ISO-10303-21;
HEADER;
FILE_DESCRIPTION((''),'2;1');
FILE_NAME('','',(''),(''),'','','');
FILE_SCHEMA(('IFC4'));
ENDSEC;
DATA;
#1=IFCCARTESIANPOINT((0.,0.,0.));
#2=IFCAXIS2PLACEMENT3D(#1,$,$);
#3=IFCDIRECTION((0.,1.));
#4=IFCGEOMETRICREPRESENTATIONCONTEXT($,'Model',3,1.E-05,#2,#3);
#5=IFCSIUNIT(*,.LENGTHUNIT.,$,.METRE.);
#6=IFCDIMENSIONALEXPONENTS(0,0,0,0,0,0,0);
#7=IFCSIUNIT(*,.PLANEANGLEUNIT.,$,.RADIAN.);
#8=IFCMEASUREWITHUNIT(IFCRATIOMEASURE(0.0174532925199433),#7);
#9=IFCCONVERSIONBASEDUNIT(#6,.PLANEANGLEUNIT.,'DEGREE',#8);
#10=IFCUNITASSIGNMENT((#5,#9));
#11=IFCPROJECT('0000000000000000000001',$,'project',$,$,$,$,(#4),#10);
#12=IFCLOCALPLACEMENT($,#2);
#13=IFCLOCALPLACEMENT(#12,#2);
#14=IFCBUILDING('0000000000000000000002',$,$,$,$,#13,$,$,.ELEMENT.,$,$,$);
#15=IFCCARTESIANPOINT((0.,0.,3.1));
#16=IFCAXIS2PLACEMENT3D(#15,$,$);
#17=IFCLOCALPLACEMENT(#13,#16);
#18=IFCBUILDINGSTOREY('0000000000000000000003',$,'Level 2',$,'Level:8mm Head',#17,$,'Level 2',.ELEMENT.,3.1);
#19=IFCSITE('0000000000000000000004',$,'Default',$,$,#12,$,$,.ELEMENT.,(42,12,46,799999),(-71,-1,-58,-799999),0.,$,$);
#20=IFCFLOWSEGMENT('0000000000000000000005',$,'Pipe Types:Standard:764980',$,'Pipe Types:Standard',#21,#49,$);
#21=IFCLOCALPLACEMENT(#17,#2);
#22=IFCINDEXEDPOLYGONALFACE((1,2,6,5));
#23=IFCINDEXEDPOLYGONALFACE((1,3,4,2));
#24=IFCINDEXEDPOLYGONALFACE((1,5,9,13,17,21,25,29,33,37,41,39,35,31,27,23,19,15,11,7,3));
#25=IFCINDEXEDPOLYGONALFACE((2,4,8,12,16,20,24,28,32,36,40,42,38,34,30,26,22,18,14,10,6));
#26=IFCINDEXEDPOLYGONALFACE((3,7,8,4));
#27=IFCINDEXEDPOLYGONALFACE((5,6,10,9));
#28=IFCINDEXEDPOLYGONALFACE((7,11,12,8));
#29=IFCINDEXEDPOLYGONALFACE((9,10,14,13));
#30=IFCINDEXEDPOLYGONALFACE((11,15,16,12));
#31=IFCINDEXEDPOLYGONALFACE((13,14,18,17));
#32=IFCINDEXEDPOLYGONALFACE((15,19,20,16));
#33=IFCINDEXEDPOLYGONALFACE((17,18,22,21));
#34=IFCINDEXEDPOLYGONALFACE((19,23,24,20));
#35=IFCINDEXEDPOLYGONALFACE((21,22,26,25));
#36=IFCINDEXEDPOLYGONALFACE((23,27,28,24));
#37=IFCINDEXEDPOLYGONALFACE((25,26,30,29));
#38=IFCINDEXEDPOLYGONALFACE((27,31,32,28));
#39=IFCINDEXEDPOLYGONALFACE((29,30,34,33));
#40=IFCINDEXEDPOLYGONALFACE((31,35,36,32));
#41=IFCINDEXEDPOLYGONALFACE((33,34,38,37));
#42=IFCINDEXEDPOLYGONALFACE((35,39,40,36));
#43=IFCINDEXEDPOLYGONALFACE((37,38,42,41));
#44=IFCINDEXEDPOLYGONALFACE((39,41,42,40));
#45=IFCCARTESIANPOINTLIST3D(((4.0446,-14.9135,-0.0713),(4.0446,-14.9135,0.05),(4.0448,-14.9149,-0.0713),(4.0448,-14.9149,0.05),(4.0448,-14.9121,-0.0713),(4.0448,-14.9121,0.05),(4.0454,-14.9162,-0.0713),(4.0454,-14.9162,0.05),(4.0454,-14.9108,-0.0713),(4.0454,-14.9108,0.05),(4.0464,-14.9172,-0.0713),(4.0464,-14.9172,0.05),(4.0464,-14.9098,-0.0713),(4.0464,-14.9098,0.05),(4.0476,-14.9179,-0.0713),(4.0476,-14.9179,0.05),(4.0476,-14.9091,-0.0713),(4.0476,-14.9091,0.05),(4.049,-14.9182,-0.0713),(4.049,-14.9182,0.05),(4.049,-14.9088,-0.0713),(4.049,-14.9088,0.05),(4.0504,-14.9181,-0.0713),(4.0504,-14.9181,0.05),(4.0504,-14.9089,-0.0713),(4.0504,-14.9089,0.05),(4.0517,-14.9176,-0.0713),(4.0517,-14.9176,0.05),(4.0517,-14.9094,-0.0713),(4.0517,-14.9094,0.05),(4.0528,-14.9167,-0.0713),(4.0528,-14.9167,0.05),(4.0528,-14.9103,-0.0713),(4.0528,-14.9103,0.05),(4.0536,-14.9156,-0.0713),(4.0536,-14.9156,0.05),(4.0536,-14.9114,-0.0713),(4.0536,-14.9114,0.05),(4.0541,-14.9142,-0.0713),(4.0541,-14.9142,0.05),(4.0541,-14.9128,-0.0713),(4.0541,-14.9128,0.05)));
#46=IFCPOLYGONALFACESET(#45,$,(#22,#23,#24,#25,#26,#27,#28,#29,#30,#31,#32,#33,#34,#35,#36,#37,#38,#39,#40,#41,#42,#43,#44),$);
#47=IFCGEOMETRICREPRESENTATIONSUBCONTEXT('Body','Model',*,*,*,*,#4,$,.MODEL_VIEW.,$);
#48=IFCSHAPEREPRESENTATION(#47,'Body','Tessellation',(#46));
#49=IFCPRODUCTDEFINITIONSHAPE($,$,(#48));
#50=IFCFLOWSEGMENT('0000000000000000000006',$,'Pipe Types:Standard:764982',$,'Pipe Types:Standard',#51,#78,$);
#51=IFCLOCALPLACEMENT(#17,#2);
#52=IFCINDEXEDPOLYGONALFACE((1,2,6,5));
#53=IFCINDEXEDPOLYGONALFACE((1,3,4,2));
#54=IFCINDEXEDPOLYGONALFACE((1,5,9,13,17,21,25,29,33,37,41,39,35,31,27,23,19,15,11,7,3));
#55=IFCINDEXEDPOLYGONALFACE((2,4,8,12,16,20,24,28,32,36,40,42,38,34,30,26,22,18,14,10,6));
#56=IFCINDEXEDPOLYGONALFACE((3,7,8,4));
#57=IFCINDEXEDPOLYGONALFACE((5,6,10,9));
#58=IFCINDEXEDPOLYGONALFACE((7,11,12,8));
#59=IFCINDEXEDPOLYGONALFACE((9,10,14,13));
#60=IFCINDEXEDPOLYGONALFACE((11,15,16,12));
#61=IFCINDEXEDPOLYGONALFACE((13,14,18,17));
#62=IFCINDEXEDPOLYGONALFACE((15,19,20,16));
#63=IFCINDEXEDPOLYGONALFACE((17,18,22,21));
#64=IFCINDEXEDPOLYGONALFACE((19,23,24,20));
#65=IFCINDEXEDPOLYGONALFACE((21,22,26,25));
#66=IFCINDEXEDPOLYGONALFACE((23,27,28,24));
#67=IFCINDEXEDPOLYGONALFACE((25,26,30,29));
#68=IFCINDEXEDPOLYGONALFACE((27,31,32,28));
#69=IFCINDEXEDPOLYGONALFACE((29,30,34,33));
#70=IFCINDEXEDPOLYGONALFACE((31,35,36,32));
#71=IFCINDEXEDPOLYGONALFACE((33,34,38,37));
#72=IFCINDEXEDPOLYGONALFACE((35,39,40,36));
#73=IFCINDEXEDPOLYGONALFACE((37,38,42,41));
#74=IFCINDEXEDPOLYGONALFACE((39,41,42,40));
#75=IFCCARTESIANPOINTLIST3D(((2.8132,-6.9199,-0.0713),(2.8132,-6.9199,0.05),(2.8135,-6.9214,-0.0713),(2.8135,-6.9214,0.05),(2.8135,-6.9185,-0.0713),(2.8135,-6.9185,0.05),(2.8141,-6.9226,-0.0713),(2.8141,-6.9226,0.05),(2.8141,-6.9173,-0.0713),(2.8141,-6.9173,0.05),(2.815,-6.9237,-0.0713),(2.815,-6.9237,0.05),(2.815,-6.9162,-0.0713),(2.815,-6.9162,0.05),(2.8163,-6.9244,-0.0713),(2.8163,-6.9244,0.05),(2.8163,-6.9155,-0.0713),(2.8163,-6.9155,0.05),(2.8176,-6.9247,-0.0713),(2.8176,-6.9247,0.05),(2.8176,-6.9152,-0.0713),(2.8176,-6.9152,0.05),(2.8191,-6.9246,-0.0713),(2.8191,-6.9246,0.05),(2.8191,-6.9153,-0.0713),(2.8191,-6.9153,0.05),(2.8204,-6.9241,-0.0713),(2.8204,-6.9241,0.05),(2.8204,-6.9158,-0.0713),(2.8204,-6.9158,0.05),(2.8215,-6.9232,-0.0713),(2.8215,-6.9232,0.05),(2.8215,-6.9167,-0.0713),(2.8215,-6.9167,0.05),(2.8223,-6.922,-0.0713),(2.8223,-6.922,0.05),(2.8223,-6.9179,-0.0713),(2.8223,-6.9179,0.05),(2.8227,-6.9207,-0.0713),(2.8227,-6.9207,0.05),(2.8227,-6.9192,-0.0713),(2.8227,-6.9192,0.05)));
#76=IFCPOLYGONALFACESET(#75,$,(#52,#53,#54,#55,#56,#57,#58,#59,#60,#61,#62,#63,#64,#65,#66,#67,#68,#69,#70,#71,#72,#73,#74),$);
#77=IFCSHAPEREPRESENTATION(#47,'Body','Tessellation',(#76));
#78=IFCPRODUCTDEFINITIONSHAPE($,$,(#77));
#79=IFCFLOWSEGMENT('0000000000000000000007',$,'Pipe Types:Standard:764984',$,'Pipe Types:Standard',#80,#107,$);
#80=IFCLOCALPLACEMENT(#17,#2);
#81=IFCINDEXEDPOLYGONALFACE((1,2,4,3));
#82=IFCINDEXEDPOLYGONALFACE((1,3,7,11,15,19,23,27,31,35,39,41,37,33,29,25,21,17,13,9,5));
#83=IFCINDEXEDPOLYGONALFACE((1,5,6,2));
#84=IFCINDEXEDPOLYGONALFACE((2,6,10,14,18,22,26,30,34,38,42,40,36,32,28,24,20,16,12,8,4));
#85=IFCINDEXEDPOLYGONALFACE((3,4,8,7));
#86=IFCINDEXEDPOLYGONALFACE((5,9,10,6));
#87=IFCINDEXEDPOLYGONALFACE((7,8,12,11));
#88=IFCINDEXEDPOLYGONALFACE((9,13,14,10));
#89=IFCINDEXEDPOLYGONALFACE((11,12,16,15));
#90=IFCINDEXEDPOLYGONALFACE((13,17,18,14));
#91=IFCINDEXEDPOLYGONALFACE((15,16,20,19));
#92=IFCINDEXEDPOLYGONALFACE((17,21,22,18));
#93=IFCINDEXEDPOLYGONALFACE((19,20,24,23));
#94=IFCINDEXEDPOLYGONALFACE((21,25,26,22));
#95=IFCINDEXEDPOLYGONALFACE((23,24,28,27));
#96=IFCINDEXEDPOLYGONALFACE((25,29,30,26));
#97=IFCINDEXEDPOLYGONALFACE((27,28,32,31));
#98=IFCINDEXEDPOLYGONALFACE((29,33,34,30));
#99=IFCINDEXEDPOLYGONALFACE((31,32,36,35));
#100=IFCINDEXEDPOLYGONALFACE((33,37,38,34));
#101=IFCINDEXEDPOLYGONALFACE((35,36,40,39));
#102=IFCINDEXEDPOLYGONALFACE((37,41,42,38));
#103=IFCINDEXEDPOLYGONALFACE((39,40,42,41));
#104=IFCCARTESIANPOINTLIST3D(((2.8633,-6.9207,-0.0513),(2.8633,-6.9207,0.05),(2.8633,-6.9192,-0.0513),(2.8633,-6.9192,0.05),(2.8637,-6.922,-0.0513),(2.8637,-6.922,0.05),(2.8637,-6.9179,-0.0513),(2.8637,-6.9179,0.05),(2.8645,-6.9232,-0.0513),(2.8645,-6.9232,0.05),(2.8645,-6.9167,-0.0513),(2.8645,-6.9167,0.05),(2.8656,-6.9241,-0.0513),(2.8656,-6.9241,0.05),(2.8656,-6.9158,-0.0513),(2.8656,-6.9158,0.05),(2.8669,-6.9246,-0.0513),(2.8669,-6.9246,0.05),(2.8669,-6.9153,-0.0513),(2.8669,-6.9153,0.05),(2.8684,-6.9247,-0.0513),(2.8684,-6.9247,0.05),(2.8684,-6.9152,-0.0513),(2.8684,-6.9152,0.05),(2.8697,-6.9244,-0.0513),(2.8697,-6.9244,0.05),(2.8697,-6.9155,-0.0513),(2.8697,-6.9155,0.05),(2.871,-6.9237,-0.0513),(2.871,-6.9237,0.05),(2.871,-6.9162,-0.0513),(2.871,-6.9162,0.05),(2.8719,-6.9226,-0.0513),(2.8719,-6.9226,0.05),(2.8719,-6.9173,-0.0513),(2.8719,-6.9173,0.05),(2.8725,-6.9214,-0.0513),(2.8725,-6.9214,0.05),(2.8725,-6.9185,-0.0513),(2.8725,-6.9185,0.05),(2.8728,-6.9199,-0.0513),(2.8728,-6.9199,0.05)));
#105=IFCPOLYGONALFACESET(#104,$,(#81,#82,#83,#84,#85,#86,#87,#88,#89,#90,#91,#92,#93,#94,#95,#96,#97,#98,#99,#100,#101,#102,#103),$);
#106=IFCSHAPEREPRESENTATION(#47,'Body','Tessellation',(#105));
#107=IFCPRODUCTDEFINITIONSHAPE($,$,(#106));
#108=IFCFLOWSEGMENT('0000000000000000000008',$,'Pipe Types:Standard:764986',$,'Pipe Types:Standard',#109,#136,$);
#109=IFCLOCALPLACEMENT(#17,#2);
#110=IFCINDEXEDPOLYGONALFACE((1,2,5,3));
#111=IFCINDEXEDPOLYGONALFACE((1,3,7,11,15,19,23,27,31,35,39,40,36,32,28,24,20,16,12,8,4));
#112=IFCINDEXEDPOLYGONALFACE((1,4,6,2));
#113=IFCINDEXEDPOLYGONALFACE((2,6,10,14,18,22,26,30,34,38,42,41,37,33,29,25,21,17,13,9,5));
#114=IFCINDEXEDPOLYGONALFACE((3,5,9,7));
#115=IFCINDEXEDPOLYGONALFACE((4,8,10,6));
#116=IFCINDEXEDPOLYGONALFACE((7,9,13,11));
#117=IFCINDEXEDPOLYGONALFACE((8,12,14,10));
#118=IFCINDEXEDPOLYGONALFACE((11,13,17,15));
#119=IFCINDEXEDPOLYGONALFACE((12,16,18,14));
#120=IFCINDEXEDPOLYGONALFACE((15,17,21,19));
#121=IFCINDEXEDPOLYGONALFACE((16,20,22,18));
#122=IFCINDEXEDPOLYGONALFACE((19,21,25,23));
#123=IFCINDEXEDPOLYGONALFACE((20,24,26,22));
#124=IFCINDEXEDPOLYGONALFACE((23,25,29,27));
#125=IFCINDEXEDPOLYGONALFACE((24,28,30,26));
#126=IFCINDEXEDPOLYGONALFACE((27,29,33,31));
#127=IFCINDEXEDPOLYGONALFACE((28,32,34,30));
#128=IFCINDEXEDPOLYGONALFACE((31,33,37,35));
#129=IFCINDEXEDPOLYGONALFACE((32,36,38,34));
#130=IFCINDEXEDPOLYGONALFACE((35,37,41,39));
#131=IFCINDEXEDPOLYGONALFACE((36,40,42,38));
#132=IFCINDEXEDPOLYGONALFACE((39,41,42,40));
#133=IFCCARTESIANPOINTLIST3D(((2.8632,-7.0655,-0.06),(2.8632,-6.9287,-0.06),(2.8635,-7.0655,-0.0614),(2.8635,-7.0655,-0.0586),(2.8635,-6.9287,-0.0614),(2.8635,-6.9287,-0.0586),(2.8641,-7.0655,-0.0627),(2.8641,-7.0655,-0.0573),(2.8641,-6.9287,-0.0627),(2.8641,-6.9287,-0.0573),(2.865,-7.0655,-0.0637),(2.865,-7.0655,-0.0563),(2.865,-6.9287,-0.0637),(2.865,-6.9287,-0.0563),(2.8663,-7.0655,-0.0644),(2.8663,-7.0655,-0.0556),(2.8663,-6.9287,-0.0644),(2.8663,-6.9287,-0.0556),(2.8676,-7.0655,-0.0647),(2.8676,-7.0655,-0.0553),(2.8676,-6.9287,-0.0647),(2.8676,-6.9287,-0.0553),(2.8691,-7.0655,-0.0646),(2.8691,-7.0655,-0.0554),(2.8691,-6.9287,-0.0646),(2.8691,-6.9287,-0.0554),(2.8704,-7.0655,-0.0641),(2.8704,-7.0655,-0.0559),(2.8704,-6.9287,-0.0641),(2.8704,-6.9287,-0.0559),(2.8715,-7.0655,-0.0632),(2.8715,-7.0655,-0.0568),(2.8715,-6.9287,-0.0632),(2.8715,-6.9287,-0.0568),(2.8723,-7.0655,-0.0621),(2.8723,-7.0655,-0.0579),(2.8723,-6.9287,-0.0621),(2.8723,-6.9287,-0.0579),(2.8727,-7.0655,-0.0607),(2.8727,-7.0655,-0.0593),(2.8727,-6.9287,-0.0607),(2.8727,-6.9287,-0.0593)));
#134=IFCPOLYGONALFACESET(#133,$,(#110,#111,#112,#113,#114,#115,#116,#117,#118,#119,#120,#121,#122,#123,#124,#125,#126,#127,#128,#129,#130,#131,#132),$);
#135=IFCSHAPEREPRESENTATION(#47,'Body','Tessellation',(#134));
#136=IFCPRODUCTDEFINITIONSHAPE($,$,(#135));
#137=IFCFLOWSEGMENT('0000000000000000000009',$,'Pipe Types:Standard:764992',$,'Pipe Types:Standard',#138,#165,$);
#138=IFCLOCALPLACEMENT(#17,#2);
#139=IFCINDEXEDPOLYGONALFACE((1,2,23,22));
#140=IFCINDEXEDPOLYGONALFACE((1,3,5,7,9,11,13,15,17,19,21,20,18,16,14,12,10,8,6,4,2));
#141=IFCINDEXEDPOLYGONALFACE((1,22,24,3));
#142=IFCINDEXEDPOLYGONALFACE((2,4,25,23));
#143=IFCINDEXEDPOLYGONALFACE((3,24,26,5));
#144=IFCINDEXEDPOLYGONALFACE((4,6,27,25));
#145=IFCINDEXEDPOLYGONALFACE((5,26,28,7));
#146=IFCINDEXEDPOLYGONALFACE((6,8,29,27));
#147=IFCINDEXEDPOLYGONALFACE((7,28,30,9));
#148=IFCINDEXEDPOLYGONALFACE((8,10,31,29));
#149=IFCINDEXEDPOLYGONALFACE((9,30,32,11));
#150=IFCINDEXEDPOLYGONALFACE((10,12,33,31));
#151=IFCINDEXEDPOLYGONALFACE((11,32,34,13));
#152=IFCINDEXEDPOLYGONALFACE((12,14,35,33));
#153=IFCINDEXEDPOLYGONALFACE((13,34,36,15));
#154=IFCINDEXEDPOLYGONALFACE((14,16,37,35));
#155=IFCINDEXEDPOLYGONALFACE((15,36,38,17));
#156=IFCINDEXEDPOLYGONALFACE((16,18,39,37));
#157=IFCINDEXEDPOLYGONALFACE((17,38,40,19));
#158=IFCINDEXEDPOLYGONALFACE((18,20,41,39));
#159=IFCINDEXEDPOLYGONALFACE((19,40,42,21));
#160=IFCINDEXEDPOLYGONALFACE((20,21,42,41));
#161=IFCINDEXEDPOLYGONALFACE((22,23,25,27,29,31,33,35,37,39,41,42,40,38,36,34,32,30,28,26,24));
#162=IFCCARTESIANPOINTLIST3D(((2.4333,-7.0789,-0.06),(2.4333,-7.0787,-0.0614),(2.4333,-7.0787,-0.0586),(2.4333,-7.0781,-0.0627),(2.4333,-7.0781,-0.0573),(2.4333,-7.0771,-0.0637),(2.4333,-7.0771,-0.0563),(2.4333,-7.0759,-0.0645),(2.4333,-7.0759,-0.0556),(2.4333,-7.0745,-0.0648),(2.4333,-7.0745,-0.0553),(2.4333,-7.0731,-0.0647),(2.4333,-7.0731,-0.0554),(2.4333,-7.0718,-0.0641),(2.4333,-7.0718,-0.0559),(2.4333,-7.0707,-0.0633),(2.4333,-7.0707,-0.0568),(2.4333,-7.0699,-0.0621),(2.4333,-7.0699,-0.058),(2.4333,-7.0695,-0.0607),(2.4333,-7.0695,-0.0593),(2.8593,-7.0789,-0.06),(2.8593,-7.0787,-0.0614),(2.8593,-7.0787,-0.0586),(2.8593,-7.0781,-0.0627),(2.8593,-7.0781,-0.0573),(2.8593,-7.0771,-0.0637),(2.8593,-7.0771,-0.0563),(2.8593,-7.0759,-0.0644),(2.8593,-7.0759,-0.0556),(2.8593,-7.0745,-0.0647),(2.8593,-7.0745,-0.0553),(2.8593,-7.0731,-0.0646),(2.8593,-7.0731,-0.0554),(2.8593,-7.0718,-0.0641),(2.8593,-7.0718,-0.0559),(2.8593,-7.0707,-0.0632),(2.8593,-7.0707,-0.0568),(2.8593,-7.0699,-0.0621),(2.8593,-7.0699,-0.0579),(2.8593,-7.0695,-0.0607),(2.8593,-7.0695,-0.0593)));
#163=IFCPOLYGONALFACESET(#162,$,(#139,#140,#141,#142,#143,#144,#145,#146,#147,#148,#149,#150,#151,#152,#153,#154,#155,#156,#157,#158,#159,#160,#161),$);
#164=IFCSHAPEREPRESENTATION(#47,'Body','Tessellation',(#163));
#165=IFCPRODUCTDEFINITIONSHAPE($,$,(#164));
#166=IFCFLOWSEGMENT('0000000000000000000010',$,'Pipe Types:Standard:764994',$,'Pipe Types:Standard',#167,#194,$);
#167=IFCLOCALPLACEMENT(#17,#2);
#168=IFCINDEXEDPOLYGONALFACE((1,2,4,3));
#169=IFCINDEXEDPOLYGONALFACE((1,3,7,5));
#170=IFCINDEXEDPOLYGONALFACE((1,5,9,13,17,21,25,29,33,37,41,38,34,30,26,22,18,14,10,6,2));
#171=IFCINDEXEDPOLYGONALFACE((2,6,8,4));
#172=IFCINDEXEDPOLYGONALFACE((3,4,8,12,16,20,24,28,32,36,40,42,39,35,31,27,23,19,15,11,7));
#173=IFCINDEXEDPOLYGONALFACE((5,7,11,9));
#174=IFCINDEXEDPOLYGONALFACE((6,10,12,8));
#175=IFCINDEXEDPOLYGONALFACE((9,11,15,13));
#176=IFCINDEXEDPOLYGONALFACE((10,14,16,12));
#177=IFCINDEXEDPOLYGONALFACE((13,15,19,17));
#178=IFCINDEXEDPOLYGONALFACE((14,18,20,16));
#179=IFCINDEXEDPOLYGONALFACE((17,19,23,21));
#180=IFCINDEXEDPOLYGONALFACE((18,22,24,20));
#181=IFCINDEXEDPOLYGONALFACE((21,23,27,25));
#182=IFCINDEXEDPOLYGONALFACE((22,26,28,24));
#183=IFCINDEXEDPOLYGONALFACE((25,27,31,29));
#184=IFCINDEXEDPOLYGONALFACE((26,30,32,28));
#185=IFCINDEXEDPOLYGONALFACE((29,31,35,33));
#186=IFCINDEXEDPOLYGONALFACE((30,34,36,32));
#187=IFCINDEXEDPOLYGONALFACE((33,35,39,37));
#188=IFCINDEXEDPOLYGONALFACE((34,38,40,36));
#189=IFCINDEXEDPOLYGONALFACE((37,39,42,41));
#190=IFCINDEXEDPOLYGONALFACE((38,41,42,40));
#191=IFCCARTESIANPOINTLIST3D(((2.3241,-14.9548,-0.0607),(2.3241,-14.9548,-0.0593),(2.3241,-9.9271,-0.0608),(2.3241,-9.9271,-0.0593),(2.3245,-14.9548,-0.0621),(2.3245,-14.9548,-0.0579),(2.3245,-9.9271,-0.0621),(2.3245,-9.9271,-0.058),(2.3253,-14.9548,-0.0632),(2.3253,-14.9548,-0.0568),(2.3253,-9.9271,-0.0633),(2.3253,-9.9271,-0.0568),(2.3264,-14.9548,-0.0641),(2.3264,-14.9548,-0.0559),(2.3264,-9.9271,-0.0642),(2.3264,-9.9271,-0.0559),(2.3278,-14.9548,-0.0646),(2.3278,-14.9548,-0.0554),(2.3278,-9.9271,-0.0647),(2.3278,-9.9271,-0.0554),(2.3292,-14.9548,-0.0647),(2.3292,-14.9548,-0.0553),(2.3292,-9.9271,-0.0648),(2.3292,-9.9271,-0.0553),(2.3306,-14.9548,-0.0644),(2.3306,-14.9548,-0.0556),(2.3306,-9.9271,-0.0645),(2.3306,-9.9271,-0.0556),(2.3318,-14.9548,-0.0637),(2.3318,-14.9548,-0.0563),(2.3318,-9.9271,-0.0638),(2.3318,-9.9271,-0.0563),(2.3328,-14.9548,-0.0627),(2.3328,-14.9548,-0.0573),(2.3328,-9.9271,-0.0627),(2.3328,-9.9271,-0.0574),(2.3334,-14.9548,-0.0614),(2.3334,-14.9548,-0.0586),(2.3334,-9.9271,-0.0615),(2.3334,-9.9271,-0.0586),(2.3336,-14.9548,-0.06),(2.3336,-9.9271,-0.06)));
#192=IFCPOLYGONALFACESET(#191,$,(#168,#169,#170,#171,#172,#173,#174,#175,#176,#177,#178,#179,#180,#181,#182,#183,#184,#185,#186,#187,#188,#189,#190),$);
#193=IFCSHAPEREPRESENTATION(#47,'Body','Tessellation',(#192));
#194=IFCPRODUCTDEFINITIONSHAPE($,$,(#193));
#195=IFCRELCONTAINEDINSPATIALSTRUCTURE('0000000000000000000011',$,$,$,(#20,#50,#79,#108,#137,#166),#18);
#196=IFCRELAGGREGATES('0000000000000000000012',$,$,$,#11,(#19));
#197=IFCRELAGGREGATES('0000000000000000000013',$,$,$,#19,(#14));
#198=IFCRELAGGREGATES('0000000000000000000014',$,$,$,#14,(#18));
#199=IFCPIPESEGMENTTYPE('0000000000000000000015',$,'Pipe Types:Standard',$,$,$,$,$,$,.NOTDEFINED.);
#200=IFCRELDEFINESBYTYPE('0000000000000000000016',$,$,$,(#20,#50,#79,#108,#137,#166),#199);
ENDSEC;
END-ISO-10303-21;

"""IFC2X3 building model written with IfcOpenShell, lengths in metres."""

from ifc_helpers import new_model, entity, si_unit, converted_unit, direction, frame, frame_2d, origin, origin_2d_with_axis, place, context, subcontext, project, spatial, circle, extrude, type_object, element, save


model = new_model("IFC2X3")

# Units and contexts
model_context = context("Model", 3, precision=1e-05, world=origin(), true_north=direction((0.0, 1.0)))
body_context = subcontext(model_context, "Body", "Model", "MODEL_VIEW")
ifc_project = project(units=[si_unit("LENGTHUNIT", "METRE"), converted_unit("PLANEANGLEUNIT", "DEGREE", entity("IfcRatioMeasure", 0.0174532925199433), si_unit("PLANEANGLEUNIT", "RADIAN"), dimensions=[0, 0, 0, 0, 0, 0, 0])], contexts=[model_context])

# Site, building, storey
site_placement = place(None, origin())
site = spatial("IfcSite", under=ifc_project, at=site_placement, Name="Default", CompositionType="ELEMENT", RefLatitude=(42, 12, 46, 799999), RefLongitude=(-71, -1, -58, -799999), RefElevation=0.0)
building_placement = place(site_placement, origin())
building = spatial("IfcBuilding", under=site, at=building_placement, CompositionType="ELEMENT")
storey_placement = place(building_placement, frame((0.0, 0.0, 3.1)))
storey = spatial("IfcBuildingStorey", under=building, at=storey_placement, Name="Level 2", ObjectType="Level:8mm Head", LongName="Level 2", CompositionType="ELEMENT", Elevation=3.1)

# Flow segments
pipe_segment_type = type_object("IfcPipeSegmentType", Name="Pipe Types:Standard", PredefinedType="NOTDEFINED")
flow_segment_1_placement = place(storey_placement, origin())
element("IfcFlowSegment", 1, at=flow_segment_1_placement, inside=storey, type_object=pipe_segment_type, Name="Pipe Types:Standard:764980", ObjectType="Pipe Types:Standard", context=body_context, shape_type="SweptSolid", body=[
    extrude(circle(Radius=0.0048, at=origin_2d_with_axis()), frame((4.0494, -14.9135, -0.0713), z_axis=(0.0, 0.0, 1.0), x_axis=(-1.0, 0.0, 0.0)), (0.0, 0.0, 1.0), 0.1213),
])
flow_segment_2_placement = place(storey_placement, origin())
element("IfcFlowSegment", 2, at=flow_segment_2_placement, inside=storey, type_object=pipe_segment_type, Name="Pipe Types:Standard:764982", ObjectType="Pipe Types:Standard", context=body_context, shape_type="SweptSolid", body=[
    extrude(circle(Radius=0.0048, at=frame_2d((0.0, 0.0), x_axis=(1.0, 0.0))), frame((2.818, -6.9199, -0.0713), z_axis=(0.0, 0.0, 1.0), x_axis=(-1.0, 0.0, 0.0)), (0.0, 0.0, 1.0), 0.1213),
])
flow_segment_3_placement = place(storey_placement, origin())
element("IfcFlowSegment", 3, at=flow_segment_3_placement, inside=storey, type_object=pipe_segment_type, Name="Pipe Types:Standard:764984", ObjectType="Pipe Types:Standard", context=body_context, shape_type="SweptSolid", body=[
    extrude(circle(Radius=0.0048, at=frame_2d((0.0, 0.0), x_axis=(1.0, 0.0))), frame((2.868, -6.9199, -0.0513)), (0.0, 0.0, 1.0), 0.1013),
])
flow_segment_4_placement = place(storey_placement, origin())
element("IfcFlowSegment", 4, at=flow_segment_4_placement, inside=storey, type_object=pipe_segment_type, Name="Pipe Types:Standard:764986", ObjectType="Pipe Types:Standard", context=body_context, shape_type="SweptSolid", body=[
    extrude(circle(Radius=0.0048, at=frame_2d((0.0, 0.0), x_axis=(1.0, 0.0))), frame((2.868, -7.0655, -0.06), z_axis=(0.0, 1.0, 0.0), x_axis=(-1.0, 0.0, 0.0)), (0.0, 0.0, 1.0), 0.1368),
])
flow_segment_5_placement = place(storey_placement, origin())
element("IfcFlowSegment", 5, at=flow_segment_5_placement, inside=storey, type_object=pipe_segment_type, Name="Pipe Types:Standard:764992", ObjectType="Pipe Types:Standard", context=body_context, shape_type="SweptSolid", body=[
    extrude(circle(Radius=0.0048, at=frame_2d((0.0, 0.0), x_axis=(1.0, 0.0))), frame((2.4333, -7.0742, -0.06), z_axis=(1.0, 0.0, 0.000059), x_axis=(0.0, -1.0, 0.0)), (0.0, 0.0, 1.0), 0.426),
])
flow_segment_6_placement = place(storey_placement, origin())
element("IfcFlowSegment", 6, at=flow_segment_6_placement, inside=storey, type_object=pipe_segment_type, Name="Pipe Types:Standard:764994", ObjectType="Pipe Types:Standard", context=body_context, shape_type="SweptSolid", body=[
    extrude(circle(Radius=0.0048, at=origin_2d_with_axis()), frame((2.3288, -14.9548, -0.06), z_axis=(0.0, 1.0, -0.00001), x_axis=(1.0, 0.0, 0.0)), (0.0, 0.0, 1.0), 5.0277),
])

save(model, "model.ifc")
